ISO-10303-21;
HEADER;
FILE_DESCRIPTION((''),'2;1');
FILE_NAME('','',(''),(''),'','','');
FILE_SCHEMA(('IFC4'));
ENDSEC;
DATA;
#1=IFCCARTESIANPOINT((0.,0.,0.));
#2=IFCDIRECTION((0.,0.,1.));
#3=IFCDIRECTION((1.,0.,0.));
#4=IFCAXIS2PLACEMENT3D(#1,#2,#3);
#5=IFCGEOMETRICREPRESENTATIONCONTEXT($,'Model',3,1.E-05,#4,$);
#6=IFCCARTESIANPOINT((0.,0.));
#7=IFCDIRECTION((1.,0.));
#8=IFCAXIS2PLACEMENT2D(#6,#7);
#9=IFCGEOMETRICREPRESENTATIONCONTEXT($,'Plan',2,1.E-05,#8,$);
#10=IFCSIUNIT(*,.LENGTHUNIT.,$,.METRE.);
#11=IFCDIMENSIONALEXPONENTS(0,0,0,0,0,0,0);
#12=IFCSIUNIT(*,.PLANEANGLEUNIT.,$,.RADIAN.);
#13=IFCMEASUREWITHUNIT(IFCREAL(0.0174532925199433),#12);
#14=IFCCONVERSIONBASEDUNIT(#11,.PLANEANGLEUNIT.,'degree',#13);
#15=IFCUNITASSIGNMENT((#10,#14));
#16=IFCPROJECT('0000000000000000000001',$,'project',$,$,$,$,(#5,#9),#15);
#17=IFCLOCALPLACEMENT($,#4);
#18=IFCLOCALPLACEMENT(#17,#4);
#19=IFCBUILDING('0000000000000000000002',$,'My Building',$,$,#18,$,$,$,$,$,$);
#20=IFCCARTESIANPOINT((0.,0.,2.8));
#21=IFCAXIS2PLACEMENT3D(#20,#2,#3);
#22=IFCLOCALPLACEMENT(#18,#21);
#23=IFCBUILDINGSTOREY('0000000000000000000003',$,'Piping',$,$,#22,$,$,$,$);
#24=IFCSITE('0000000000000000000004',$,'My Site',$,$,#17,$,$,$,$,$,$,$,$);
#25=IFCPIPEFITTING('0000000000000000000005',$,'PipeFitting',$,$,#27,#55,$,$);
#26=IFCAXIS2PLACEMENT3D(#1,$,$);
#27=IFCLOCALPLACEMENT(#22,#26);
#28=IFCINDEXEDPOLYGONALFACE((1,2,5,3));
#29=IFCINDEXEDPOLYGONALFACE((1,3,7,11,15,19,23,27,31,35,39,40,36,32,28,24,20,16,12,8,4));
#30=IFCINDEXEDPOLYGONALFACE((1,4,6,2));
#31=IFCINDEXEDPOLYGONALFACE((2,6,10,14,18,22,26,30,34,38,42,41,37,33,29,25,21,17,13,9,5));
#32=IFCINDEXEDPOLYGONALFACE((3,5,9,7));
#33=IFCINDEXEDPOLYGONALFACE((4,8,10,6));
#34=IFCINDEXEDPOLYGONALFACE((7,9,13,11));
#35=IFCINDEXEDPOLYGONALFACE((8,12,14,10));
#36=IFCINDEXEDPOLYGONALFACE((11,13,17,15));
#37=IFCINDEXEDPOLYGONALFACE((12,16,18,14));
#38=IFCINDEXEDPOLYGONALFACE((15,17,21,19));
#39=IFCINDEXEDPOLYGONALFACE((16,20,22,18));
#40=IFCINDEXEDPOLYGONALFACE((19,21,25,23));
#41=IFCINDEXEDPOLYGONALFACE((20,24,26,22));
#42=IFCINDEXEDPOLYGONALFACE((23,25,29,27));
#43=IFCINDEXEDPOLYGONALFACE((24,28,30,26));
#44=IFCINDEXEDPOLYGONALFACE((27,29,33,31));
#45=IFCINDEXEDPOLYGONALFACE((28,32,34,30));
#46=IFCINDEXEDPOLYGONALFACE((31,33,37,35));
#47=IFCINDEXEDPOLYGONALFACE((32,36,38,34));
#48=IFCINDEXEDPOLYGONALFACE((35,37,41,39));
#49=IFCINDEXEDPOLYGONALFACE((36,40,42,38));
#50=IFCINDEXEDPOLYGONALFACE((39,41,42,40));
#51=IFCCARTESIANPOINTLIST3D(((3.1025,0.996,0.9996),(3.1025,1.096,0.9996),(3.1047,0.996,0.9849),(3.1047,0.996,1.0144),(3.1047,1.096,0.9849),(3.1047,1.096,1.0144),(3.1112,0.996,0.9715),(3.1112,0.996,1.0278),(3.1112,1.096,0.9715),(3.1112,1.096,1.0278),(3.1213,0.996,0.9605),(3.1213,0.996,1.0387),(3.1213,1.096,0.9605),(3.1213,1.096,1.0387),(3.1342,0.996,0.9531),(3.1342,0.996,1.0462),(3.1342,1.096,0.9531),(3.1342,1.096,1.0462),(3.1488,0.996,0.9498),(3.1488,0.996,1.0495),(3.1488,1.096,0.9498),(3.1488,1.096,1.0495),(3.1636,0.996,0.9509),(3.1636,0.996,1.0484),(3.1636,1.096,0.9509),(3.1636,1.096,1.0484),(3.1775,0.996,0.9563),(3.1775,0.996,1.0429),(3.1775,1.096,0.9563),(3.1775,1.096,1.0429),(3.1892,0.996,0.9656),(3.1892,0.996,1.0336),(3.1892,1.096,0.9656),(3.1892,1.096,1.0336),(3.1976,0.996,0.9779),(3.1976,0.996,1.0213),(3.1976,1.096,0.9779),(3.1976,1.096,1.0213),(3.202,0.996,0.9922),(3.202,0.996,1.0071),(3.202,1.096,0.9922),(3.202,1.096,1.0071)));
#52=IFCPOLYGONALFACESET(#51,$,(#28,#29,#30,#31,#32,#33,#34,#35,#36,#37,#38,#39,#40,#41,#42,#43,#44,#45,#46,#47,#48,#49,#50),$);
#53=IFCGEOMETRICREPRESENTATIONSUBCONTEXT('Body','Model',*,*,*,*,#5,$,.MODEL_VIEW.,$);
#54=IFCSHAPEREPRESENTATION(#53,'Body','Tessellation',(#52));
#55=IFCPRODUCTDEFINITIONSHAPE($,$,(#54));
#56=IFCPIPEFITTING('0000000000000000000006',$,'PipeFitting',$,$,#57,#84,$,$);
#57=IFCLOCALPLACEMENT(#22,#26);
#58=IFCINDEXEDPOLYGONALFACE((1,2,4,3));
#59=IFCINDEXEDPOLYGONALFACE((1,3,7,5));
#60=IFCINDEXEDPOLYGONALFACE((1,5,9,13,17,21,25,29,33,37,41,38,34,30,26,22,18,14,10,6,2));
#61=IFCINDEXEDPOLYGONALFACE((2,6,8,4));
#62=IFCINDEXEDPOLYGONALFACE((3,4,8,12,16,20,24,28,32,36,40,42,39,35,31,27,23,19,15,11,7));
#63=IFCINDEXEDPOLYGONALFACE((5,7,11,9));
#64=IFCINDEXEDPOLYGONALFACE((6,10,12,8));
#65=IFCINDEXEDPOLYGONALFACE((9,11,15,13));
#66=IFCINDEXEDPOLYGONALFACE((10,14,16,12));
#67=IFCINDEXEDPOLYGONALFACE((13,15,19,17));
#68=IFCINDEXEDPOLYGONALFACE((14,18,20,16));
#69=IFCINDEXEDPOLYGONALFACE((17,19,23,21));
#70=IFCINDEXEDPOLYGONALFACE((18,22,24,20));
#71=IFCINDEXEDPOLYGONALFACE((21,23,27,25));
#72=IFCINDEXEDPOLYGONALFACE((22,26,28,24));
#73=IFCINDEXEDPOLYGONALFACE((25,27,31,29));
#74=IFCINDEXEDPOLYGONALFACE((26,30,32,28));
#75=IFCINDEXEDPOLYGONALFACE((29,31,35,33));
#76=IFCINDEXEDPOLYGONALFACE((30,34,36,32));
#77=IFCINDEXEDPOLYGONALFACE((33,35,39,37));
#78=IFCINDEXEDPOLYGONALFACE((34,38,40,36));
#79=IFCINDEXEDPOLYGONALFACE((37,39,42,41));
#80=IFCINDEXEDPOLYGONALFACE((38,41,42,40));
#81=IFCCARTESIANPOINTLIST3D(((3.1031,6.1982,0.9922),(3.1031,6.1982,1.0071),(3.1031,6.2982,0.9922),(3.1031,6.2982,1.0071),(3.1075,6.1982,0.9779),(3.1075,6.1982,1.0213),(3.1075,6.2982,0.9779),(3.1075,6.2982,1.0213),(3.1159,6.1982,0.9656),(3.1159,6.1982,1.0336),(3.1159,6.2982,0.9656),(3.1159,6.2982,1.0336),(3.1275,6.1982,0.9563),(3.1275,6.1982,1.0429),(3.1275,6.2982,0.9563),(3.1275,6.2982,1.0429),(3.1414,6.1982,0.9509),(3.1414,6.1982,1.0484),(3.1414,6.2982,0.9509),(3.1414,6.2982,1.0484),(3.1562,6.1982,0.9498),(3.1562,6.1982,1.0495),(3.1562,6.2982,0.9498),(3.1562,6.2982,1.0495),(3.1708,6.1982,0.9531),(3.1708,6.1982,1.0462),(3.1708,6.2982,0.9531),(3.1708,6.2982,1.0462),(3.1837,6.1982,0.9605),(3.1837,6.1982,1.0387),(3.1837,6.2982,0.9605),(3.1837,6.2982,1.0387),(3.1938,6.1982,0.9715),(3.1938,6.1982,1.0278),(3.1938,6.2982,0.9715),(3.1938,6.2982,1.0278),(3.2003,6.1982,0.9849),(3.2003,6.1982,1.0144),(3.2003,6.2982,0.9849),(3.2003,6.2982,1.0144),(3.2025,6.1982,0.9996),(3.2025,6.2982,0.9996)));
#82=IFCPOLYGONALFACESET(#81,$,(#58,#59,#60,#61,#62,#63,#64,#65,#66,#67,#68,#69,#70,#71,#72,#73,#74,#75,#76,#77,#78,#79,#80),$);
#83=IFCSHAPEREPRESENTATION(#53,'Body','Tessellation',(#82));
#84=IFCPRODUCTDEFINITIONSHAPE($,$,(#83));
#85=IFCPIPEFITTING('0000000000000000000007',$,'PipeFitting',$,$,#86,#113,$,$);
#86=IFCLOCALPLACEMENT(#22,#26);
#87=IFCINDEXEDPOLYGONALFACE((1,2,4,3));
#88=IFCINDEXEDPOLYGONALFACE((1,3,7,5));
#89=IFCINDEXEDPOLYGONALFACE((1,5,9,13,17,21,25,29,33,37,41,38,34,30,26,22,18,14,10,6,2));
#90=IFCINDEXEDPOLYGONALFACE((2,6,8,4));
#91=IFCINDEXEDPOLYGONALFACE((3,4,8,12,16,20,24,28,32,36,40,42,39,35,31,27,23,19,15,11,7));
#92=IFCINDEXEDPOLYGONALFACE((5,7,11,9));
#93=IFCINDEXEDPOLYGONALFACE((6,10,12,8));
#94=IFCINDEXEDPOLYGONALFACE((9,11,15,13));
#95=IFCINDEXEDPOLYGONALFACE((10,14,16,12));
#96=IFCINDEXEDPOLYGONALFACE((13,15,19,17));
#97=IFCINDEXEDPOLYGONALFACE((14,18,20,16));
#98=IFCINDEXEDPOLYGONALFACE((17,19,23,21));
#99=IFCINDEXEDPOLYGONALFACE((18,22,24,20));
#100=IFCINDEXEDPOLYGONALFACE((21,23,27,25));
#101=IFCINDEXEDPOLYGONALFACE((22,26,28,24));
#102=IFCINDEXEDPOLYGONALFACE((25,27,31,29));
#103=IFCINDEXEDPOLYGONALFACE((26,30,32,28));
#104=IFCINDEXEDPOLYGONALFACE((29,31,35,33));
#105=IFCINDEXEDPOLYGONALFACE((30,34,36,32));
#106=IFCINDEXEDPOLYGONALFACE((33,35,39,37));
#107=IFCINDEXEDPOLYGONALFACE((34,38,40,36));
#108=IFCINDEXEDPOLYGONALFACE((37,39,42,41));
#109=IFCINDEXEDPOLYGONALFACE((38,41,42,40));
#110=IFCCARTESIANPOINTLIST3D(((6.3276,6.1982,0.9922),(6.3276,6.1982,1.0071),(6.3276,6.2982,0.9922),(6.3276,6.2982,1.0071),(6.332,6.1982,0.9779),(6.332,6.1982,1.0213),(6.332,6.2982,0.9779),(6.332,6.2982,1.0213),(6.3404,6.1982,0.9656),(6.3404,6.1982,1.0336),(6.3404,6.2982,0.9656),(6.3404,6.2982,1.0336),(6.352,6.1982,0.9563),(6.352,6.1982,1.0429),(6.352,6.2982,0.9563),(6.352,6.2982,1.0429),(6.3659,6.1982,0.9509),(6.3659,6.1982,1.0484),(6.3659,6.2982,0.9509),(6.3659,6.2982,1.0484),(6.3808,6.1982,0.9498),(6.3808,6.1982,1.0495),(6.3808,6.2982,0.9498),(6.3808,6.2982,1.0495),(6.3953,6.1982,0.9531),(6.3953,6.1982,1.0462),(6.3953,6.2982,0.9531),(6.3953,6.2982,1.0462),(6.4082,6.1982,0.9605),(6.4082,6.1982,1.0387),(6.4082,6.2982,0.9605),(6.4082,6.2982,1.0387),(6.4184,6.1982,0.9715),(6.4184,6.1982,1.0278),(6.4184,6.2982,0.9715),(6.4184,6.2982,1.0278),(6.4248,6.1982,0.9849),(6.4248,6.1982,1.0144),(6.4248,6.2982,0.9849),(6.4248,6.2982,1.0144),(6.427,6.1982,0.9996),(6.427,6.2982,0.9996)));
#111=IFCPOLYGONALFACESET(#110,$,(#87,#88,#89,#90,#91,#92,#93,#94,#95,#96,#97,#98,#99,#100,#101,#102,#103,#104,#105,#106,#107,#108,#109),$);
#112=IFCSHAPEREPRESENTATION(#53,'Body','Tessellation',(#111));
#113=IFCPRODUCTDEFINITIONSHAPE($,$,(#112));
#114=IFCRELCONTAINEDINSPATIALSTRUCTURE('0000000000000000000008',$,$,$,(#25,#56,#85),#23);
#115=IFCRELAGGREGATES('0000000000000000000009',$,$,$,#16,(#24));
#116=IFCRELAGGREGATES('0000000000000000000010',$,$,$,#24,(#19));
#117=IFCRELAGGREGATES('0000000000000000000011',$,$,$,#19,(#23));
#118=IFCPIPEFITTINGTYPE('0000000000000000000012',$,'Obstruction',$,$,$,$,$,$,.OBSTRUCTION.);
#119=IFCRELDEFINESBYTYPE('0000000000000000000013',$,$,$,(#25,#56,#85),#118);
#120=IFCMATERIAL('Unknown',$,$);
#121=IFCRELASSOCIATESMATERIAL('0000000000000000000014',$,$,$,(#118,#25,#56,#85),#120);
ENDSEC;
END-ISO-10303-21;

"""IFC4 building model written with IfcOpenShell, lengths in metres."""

from ifc_helpers import new_model, entity, si_unit, converted_unit, frame, origin_with_axes, origin_2d_with_axis, place, context, subcontext, project, spatial, circle, extrude, material, material_profile, profile_set, profile_usage, type_object, element, save


model = new_model("IFC4")

# Units and contexts
model_context = context("Model", 3, precision=1e-05, world=origin_with_axes())
plan_context = context("Plan", 2, precision=1e-05, world=origin_2d_with_axis())
body_context = subcontext(model_context, "Body", "Model", "MODEL_VIEW")
ifc_project = project(units=[si_unit("LENGTHUNIT", "METRE"), converted_unit("PLANEANGLEUNIT", "degree", entity("IfcReal", 0.0174532925199433), si_unit("PLANEANGLEUNIT", "RADIAN"), dimensions=[0, 0, 0, 0, 0, 0, 0])], contexts=[model_context, plan_context])

# Site, building, storey
site_placement = place(None, origin_with_axes())
site = spatial("IfcSite", under=ifc_project, at=site_placement, Name="My Site")
building_placement = place(site_placement, origin_with_axes())
building = spatial("IfcBuilding", under=site, at=building_placement, Name="My Building")
storey_placement = place(building_placement, frame((0.0, 0.0, 2.8), z_axis=(0.0, 0.0, 1.0), x_axis=(1.0, 0.0, 0.0)))
storey = spatial("IfcBuildingStorey", under=building, at=storey_placement, Name="Piping")

# Shared definitions
ifc_material = material(Name="Unknown")

# Pipe fittings
ifc_material_profile_1 = material_profile(ifc_material, circle(Radius=0.05))
ifc_profile_set_1 = profile_set([ifc_material_profile_1])
pipe_fitting_type_1 = type_object("IfcPipeFittingType", Name="Obstruction", PredefinedType="OBSTRUCTION", material=ifc_profile_set_1)
ifc_profile_usage_1 = profile_usage(ifc_profile_set_1, cardinal=5)
pipe_fitting_1_placement = place(storey_placement, frame((3.1525, 0.996, 0.9996), z_axis=(0.0, 1.0, 0.0), x_axis=(-1.0, 0.0, 0.0)))
element("IfcPipeFitting", 1, at=pipe_fitting_1_placement, inside=storey, type_object=pipe_fitting_type_1, material=ifc_profile_usage_1, Name="PipeFitting", context=body_context, shape_type="SweptSolid", body=[
    extrude(circle(Radius=0.05), origin_with_axes(), (0.0, 0.0, 1.0), 0.1),
])
ifc_profile_usage_2 = profile_usage(ifc_profile_set_1, cardinal=5)
pipe_fitting_2_placement = place(storey_placement, frame((3.1525, 6.2982, 0.9996), z_axis=(0.0, -1.0, 0.0), x_axis=(1.0, 0.0, 0.0)))
element("IfcPipeFitting", 2, at=pipe_fitting_2_placement, inside=storey, type_object=pipe_fitting_type_1, material=ifc_profile_usage_2, Name="PipeFitting", context=body_context, shape_type="SweptSolid", body=[
    extrude(circle(Radius=0.05), origin_with_axes(), (0.0, 0.0, 1.0), 0.1),
])
ifc_profile_usage_3 = profile_usage(ifc_profile_set_1, cardinal=5)
pipe_fitting_3_placement = place(storey_placement, frame((6.377, 6.2982, 0.9996), z_axis=(0.0, -1.0, 0.0), x_axis=(1.0, 0.0, 0.0)))
element("IfcPipeFitting", 3, at=pipe_fitting_3_placement, inside=storey, type_object=pipe_fitting_type_1, material=ifc_profile_usage_3, Name="PipeFitting", context=body_context, shape_type="SweptSolid", body=[
    extrude(circle(Radius=0.05), origin_with_axes(), (0.0, 0.0, 1.0), 0.1),
])

save(model, "model.ifc")
